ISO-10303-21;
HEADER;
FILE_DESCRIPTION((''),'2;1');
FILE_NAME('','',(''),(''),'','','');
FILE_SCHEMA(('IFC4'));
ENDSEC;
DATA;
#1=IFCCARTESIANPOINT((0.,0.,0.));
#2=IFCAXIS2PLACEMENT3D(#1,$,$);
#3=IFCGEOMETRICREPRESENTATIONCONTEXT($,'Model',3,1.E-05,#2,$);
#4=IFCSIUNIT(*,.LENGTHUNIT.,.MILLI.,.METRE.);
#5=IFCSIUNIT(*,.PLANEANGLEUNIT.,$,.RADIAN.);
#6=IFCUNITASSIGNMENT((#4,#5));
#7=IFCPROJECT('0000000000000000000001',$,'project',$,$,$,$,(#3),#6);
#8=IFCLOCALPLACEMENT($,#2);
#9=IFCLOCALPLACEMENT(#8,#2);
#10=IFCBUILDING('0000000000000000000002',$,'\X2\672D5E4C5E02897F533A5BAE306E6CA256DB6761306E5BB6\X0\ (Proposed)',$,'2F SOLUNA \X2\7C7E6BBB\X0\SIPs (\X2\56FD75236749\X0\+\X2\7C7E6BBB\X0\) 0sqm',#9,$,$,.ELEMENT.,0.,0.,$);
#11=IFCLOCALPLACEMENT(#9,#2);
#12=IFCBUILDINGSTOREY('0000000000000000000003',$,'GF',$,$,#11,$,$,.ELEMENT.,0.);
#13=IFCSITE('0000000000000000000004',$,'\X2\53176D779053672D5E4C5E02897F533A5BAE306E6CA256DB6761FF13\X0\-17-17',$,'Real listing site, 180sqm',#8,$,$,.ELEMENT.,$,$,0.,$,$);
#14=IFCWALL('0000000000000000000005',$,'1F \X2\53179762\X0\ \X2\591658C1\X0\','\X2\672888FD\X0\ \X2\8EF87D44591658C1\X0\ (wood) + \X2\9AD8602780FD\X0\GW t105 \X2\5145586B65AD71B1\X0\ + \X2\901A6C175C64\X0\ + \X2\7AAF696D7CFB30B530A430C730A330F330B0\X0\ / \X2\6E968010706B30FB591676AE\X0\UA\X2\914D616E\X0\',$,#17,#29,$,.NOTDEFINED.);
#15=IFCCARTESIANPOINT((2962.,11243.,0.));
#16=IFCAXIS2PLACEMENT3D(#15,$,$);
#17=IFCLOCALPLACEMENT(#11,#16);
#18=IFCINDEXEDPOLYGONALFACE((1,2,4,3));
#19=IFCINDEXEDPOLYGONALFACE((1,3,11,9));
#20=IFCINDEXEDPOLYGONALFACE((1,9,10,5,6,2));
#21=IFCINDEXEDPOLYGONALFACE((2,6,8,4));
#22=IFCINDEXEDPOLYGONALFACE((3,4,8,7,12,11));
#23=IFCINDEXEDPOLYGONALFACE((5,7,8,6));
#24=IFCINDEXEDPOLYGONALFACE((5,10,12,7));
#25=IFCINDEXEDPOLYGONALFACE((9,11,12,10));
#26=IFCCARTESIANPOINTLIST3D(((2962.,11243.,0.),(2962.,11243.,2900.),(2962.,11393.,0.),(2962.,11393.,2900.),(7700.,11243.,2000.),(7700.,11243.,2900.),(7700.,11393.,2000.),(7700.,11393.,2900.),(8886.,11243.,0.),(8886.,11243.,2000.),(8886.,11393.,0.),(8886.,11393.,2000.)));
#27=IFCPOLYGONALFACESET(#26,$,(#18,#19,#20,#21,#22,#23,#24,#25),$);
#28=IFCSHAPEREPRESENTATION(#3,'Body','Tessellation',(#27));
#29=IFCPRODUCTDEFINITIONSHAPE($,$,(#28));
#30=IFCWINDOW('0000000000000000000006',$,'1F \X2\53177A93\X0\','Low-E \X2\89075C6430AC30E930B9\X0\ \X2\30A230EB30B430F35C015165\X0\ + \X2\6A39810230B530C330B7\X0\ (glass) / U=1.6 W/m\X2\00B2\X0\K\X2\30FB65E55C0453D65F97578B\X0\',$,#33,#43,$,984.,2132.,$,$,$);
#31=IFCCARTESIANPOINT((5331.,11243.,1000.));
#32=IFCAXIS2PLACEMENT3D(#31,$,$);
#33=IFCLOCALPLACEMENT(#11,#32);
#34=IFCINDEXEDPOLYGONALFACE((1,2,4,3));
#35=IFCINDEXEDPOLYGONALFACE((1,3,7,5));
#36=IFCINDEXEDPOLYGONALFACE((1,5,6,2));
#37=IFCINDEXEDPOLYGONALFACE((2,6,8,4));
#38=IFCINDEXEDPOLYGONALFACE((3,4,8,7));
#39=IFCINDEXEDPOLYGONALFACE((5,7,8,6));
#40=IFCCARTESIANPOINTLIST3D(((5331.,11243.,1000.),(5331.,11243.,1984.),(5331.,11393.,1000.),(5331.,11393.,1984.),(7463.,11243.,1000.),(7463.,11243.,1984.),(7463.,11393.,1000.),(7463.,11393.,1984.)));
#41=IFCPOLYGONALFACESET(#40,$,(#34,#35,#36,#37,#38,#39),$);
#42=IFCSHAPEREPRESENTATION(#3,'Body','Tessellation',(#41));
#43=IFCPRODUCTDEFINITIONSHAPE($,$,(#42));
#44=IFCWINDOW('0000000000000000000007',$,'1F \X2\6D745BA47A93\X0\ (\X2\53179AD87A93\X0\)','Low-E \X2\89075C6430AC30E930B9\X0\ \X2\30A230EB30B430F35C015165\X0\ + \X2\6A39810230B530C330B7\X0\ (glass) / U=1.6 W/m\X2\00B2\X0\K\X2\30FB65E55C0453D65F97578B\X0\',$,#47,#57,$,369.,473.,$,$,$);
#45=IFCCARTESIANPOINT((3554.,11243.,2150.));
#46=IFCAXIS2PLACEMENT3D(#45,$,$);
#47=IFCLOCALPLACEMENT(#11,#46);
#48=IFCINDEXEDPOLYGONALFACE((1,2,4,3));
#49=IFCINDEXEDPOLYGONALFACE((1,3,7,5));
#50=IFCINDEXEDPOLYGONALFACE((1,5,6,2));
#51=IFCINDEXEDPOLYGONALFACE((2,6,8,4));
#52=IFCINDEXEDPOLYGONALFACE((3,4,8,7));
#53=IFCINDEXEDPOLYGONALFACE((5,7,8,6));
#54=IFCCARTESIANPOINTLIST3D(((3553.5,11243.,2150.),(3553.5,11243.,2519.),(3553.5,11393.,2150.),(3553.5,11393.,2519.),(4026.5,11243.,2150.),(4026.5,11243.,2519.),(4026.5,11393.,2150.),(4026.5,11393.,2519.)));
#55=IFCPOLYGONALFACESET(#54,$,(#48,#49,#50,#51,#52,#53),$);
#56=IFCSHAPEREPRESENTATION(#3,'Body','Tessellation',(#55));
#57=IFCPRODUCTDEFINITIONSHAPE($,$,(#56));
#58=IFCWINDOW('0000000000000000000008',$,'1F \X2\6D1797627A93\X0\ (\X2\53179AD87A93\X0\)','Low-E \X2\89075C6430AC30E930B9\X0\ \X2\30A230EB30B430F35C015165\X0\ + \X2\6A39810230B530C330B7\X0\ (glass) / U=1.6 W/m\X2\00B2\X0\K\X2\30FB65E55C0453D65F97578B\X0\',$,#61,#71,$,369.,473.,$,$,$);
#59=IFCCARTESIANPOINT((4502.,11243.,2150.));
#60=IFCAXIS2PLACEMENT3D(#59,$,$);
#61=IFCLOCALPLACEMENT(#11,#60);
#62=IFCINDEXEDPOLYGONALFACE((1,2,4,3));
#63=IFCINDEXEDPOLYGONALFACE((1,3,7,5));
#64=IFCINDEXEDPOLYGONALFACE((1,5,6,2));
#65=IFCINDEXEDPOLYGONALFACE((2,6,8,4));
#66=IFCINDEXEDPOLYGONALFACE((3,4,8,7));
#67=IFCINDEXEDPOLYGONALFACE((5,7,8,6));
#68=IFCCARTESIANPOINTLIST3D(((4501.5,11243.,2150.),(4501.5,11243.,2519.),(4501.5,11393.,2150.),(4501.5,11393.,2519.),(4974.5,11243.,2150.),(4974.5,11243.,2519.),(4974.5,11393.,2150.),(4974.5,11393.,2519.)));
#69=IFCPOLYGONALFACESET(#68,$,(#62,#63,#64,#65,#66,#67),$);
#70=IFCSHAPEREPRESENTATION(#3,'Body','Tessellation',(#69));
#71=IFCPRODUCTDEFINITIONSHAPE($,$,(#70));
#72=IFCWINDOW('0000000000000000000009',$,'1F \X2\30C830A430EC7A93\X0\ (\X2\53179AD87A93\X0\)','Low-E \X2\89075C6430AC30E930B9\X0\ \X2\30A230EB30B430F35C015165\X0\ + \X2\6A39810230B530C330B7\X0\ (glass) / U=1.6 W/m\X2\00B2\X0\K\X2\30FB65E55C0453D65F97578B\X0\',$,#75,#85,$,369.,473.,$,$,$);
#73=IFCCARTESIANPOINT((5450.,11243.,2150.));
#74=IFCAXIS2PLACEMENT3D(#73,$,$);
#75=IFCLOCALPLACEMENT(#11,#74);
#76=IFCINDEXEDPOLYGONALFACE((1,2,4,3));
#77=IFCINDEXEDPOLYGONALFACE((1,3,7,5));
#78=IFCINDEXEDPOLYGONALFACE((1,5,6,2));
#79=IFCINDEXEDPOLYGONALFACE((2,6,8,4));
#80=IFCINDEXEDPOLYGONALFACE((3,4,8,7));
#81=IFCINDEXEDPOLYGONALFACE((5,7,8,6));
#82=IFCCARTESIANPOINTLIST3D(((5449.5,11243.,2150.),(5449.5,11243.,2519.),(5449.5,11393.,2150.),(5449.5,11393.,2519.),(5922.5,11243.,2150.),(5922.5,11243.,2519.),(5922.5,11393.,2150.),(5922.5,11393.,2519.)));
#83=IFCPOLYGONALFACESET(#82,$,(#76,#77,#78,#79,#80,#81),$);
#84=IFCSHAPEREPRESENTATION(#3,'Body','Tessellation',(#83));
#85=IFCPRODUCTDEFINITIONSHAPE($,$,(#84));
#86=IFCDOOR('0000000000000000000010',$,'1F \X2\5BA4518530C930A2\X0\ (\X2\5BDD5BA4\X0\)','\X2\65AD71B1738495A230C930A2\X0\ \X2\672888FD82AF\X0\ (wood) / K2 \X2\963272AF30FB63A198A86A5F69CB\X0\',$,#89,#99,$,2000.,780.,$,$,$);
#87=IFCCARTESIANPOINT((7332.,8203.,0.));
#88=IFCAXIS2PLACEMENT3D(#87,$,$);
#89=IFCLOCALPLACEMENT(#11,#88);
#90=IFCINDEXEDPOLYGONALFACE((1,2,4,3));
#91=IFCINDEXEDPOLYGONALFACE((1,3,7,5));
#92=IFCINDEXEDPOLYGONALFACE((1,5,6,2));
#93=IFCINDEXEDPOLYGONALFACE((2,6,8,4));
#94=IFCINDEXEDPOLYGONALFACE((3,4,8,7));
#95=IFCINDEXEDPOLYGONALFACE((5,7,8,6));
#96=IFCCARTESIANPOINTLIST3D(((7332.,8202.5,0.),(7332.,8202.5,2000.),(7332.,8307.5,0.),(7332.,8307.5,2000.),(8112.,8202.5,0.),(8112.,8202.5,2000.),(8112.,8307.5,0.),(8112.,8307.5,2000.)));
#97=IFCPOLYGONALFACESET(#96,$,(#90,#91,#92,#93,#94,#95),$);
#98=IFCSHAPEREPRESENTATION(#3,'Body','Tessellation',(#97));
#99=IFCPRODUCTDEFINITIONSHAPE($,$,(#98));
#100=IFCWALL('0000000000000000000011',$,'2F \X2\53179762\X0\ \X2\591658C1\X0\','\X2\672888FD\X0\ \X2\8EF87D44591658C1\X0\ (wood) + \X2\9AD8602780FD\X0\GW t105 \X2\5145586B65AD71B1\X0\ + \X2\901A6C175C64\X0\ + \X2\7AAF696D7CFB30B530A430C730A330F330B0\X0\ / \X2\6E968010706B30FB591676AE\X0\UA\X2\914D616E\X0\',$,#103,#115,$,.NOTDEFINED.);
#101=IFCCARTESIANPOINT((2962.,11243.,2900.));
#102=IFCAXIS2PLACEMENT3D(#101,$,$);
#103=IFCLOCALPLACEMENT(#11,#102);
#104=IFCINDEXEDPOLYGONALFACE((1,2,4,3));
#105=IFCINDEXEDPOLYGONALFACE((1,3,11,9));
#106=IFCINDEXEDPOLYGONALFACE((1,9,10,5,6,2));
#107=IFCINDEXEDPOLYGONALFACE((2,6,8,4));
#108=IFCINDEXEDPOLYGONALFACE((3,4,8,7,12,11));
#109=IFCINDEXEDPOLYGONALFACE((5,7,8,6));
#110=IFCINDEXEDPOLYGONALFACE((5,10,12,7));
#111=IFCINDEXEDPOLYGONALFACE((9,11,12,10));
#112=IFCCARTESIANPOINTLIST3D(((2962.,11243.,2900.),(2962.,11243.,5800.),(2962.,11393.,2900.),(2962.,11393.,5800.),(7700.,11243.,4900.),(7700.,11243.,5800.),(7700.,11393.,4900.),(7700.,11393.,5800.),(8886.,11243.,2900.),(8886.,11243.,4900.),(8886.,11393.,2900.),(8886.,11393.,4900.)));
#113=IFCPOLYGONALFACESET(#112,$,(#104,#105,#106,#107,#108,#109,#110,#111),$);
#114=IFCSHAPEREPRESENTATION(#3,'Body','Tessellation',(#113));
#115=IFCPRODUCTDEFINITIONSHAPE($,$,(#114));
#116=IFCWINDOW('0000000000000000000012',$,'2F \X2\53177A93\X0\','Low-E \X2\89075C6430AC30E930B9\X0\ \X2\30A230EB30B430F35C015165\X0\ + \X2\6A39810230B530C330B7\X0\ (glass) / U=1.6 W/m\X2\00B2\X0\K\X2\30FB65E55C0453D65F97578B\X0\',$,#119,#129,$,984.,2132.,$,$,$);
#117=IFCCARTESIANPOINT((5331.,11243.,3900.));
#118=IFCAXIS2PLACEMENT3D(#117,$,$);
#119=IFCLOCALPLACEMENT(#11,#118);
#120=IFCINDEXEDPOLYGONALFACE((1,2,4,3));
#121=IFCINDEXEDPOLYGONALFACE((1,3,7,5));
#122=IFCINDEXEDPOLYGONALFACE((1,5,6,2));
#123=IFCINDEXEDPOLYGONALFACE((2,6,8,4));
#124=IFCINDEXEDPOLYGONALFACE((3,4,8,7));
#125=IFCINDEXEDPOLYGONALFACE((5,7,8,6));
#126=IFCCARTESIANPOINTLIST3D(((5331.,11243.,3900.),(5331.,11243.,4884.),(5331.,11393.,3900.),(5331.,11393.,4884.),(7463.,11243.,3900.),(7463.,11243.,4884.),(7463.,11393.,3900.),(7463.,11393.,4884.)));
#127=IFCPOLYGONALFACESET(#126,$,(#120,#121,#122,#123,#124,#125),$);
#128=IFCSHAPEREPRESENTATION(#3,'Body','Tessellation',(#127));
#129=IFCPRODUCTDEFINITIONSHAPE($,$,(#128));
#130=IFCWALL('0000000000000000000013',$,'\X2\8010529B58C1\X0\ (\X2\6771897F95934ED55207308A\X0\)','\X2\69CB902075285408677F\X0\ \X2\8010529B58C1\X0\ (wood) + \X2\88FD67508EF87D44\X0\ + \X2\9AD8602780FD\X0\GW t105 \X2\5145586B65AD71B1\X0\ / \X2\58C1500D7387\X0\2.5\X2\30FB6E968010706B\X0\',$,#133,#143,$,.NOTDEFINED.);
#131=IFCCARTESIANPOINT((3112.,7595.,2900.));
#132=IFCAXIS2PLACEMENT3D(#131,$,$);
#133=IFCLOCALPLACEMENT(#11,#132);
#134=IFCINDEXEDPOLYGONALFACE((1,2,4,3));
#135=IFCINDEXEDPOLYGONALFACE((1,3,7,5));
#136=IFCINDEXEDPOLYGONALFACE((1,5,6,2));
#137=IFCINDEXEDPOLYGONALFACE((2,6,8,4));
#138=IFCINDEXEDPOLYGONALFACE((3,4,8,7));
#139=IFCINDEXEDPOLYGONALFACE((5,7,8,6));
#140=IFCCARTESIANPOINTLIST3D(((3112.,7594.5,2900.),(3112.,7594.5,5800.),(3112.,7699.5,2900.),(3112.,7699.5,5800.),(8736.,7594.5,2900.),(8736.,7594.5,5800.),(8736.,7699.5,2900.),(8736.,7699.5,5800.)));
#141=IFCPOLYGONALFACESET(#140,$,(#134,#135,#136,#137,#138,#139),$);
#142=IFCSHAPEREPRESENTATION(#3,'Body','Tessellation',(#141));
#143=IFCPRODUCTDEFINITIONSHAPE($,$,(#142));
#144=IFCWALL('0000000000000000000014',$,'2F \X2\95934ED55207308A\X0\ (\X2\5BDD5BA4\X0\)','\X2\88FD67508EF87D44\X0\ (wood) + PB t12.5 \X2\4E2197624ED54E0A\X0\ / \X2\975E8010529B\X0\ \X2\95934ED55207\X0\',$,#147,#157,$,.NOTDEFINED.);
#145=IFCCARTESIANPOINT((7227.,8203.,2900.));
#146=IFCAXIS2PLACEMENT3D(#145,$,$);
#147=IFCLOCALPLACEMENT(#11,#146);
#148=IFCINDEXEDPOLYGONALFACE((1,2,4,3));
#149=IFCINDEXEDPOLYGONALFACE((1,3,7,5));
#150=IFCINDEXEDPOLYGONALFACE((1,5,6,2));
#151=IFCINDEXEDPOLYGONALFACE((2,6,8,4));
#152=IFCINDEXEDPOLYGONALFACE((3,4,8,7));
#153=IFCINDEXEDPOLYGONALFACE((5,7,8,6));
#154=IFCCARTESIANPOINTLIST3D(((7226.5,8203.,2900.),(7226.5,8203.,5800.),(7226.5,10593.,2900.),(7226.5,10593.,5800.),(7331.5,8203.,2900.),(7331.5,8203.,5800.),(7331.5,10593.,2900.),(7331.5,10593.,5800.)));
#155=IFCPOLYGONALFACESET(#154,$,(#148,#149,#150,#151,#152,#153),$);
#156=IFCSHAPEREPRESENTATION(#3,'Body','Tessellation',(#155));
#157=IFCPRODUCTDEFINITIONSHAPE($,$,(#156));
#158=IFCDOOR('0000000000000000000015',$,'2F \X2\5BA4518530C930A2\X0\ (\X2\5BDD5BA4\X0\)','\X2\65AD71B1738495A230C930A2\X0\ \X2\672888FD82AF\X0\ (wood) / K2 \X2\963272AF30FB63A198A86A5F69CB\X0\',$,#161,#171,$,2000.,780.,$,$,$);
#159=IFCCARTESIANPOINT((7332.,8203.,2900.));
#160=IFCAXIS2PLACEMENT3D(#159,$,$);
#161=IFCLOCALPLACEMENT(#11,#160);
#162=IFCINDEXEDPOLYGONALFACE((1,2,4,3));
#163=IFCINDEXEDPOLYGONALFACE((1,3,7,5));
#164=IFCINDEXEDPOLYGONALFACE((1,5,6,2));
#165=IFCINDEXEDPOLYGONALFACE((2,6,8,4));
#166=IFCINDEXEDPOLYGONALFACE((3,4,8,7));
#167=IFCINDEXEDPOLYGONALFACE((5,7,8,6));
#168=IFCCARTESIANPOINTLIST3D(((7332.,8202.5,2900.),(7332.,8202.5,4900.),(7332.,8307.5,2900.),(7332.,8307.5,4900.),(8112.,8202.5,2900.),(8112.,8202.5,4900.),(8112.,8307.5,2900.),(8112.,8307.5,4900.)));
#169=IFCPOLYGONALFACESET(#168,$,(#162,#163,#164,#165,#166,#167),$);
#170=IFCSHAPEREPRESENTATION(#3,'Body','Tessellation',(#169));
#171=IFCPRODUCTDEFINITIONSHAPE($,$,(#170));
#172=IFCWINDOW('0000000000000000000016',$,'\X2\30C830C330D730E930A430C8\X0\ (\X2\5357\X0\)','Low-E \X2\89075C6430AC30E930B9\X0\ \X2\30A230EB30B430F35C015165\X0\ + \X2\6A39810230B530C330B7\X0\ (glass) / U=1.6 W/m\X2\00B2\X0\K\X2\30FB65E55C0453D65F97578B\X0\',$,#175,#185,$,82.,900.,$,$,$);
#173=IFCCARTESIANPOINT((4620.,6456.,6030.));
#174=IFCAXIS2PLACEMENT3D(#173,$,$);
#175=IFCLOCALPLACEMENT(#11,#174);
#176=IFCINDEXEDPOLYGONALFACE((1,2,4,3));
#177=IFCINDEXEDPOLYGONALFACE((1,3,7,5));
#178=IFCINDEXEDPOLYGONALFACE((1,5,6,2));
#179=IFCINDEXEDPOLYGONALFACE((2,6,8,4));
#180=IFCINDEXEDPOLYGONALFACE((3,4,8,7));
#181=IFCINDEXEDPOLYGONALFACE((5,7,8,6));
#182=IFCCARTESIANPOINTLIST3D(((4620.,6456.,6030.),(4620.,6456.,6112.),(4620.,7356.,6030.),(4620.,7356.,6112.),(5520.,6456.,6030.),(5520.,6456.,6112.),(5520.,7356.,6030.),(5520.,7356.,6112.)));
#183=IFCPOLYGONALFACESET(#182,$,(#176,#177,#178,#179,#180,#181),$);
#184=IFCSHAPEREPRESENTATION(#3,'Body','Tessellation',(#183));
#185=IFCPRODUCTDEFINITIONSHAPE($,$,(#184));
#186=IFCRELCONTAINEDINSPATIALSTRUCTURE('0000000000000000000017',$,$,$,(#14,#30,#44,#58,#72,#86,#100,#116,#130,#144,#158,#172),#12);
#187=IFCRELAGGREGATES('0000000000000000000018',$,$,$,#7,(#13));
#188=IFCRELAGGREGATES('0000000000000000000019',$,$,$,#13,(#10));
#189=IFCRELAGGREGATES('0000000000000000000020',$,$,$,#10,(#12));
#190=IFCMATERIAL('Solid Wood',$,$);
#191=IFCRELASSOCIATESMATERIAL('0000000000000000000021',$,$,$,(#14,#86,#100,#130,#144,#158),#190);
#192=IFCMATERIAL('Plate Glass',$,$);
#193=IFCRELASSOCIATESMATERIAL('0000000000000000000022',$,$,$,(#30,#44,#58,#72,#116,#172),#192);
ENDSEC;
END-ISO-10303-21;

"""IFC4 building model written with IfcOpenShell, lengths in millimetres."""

from ifc_helpers import new_model, si_unit, frame, frame_2d, origin, place, context, project, spatial, rectangle, extrude, material, element, fill, save


model = new_model("IFC4")

# Units and contexts
model_context = context("Model", 3, precision=1e-05, world=origin())
ifc_project = project(units=[si_unit("LENGTHUNIT", "METRE", prefix="MILLI"), si_unit("PLANEANGLEUNIT", "RADIAN")], contexts=[model_context])

# Site, building, storey
site_placement = place(None, origin())
site = spatial("IfcSite", under=ifc_project, at=site_placement, Name="北海道札幌市西区宮の沢四条３-17-17", ObjectType="Real listing site, 180sqm", CompositionType="ELEMENT", RefElevation=0.0)
building_placement = place(site_placement, origin())
building = spatial("IfcBuilding", under=site, at=building_placement, Name="札幌市西区宮の沢四条の家 (Proposed)", ObjectType="2F SOLUNA 籾殻SIPs (国産杉+籾殻) 0sqm", CompositionType="ELEMENT", ElevationOfRefHeight=0.0, ElevationOfTerrain=0.0)
storey_placement = place(building_placement, origin())
storey = spatial("IfcBuildingStorey", under=building, at=storey_placement, Name="GF", CompositionType="ELEMENT", Elevation=0.0)

# Wall, openings, windows
ifc_material_1 = material(Name="Solid Wood")
wall_1_placement = place(storey_placement, frame((2962.0, 11243.0, 0.0)))
wall_1 = element("IfcWall", 1, at=wall_1_placement, inside=storey, material=ifc_material_1, Name="1F 北面 外壁", Description="木製 軸組外壁 (wood) + 高性能GW t105 充填断熱 + 通気層 + 窯業系サイディング / 準耐火・外皮UA配慮", PredefinedType="NOTDEFINED", context=model_context, shape_type="SweptSolid", body=[
    extrude(rectangle(XDim=5924.0, YDim=150.0, at=frame_2d((2962.0, 75.0))), frame((2962.0, 11243.0, 0.0)), (0.0, 0.0, 1.0), 2900.0),
])
opening_1_placement = place(storey_placement, frame((5331.0, 11243.0, 1000.0)))
opening_1 = element("IfcOpeningElement", 2, at=opening_1_placement, cuts=wall_1, PredefinedType="NOTDEFINED", context=model_context, shape_type="SweptSolid", body=[
    extrude(rectangle(XDim=2132.0, YDim=150.0, at=frame_2d((1066.0, 75.0))), frame((5331.0, 11243.0, 1000.0)), (0.0, 0.0, 1.0), 984.0),
])
opening_2_placement = place(storey_placement, frame((3554.0, 11243.0, 2150.0)))
opening_2 = element("IfcOpeningElement", 3, at=opening_2_placement, cuts=wall_1, PredefinedType="NOTDEFINED", context=model_context, shape_type="SweptSolid", body=[
    extrude(rectangle(XDim=473.0, YDim=150.0, at=frame_2d((236.0, 75.0))), frame((3554.0, 11243.0, 2150.0)), (0.0, 0.0, 1.0), 369.0),
])
opening_3_placement = place(storey_placement, frame((4502.0, 11243.0, 2150.0)))
opening_3 = element("IfcOpeningElement", 4, at=opening_3_placement, cuts=wall_1, PredefinedType="NOTDEFINED", context=model_context, shape_type="SweptSolid", body=[
    extrude(rectangle(XDim=473.0, YDim=150.0, at=frame_2d((236.0, 75.0))), frame((4502.0, 11243.0, 2150.0)), (0.0, 0.0, 1.0), 369.0),
])
opening_4_placement = place(storey_placement, frame((5450.0, 11243.0, 2150.0)))
opening_4 = element("IfcOpeningElement", 5, at=opening_4_placement, cuts=wall_1, PredefinedType="NOTDEFINED", context=model_context, shape_type="SweptSolid", body=[
    extrude(rectangle(XDim=473.0, YDim=150.0, at=frame_2d((236.0, 75.0))), frame((5450.0, 11243.0, 2150.0)), (0.0, 0.0, 1.0), 369.0),
])
ifc_material_2 = material(Name="Plate Glass")
window_1_placement = place(storey_placement, frame((5331.0, 11243.0, 1000.0)))
window_1 = element("IfcWindow", 6, at=window_1_placement, inside=storey, material=ifc_material_2, Name="1F 北窓", Description="Low-E 複層ガラス アルゴン封入 + 樹脂サッシ (glass) / U=1.6 W/m²K・日射取得型", OverallHeight=984.0, OverallWidth=2132.0, context=model_context, shape_type="SweptSolid", body=[
    extrude(rectangle(XDim=2132.0, YDim=150.0, at=frame_2d((1066.0, 75.0))), frame((5331.0, 11243.0, 1000.0)), (0.0, 0.0, 1.0), 984.0),
])
fill(opening_1, window_1)
window_2_placement = place(storey_placement, frame((3554.0, 11243.0, 2150.0)))
window_2 = element("IfcWindow", 7, at=window_2_placement, inside=storey, material=ifc_material_2, Name="1F 浴室窓 (北高窓)", Description="Low-E 複層ガラス アルゴン封入 + 樹脂サッシ (glass) / U=1.6 W/m²K・日射取得型", OverallHeight=369.0, OverallWidth=473.0, context=model_context, shape_type="SweptSolid", body=[
    extrude(rectangle(XDim=473.0, YDim=150.0, at=frame_2d((236.0, 75.0))), frame((3554.0, 11243.0, 2150.0)), (0.0, 0.0, 1.0), 369.0),
])
fill(opening_2, window_2)
window_3_placement = place(storey_placement, frame((4502.0, 11243.0, 2150.0)))
window_3 = element("IfcWindow", 8, at=window_3_placement, inside=storey, material=ifc_material_2, Name="1F 洗面窓 (北高窓)", Description="Low-E 複層ガラス アルゴン封入 + 樹脂サッシ (glass) / U=1.6 W/m²K・日射取得型", OverallHeight=369.0, OverallWidth=473.0, context=model_context, shape_type="SweptSolid", body=[
    extrude(rectangle(XDim=473.0, YDim=150.0, at=frame_2d((236.0, 75.0))), frame((4502.0, 11243.0, 2150.0)), (0.0, 0.0, 1.0), 369.0),
])
fill(opening_3, window_3)
window_4_placement = place(storey_placement, frame((5450.0, 11243.0, 2150.0)))
window_4 = element("IfcWindow", 9, at=window_4_placement, inside=storey, material=ifc_material_2, Name="1F トイレ窓 (北高窓)", Description="Low-E 複層ガラス アルゴン封入 + 樹脂サッシ (glass) / U=1.6 W/m²K・日射取得型", OverallHeight=369.0, OverallWidth=473.0, context=model_context, shape_type="SweptSolid", body=[
    extrude(rectangle(XDim=473.0, YDim=150.0, at=frame_2d((236.0, 75.0))), frame((5450.0, 11243.0, 2150.0)), (0.0, 0.0, 1.0), 369.0),
])
fill(opening_4, window_4)

# Door
door_1_placement = place(storey_placement, frame((7332.0, 8203.0, 0.0)))
element("IfcDoor", 10, at=door_1_placement, inside=storey, material=ifc_material_1, Name="1F 室内ドア (寝室)", Description="断熱玄関ドア 木製芯 (wood) / K2 防犯・採風機構", OverallHeight=2000.0, OverallWidth=780.0, context=model_context, shape_type="SweptSolid", body=[
    extrude(rectangle(XDim=780.0, YDim=105.0, at=frame_2d((390.0, 52.0))), frame((7332.0, 8203.0, 0.0)), (0.0, 0.0, 1.0), 2000.0),
])

# Wall, opening, window
wall_2_placement = place(storey_placement, frame((2962.0, 11243.0, 2900.0)))
wall_2 = element("IfcWall", 11, at=wall_2_placement, inside=storey, material=ifc_material_1, Name="2F 北面 外壁", Description="木製 軸組外壁 (wood) + 高性能GW t105 充填断熱 + 通気層 + 窯業系サイディング / 準耐火・外皮UA配慮", PredefinedType="NOTDEFINED", context=model_context, shape_type="SweptSolid", body=[
    extrude(rectangle(XDim=5924.0, YDim=150.0, at=frame_2d((2962.0, 75.0))), frame((2962.0, 11243.0, 2900.0)), (0.0, 0.0, 1.0), 2900.0),
])
opening_5_placement = place(storey_placement, frame((5331.0, 11243.0, 3900.0)))
opening_5 = element("IfcOpeningElement", 12, at=opening_5_placement, cuts=wall_2, PredefinedType="NOTDEFINED", context=model_context, shape_type="SweptSolid", body=[
    extrude(rectangle(XDim=2132.0, YDim=150.0, at=frame_2d((1066.0, 75.0))), frame((5331.0, 11243.0, 3900.0)), (0.0, 0.0, 1.0), 984.0),
])
window_5_placement = place(storey_placement, frame((5331.0, 11243.0, 3900.0)))
window_5 = element("IfcWindow", 13, at=window_5_placement, inside=storey, material=ifc_material_2, Name="2F 北窓", Description="Low-E 複層ガラス アルゴン封入 + 樹脂サッシ (glass) / U=1.6 W/m²K・日射取得型", OverallHeight=984.0, OverallWidth=2132.0, context=model_context, shape_type="SweptSolid", body=[
    extrude(rectangle(XDim=2132.0, YDim=150.0, at=frame_2d((1066.0, 75.0))), frame((5331.0, 11243.0, 3900.0)), (0.0, 0.0, 1.0), 984.0),
])
fill(opening_5, window_5)

# Walls
wall_3_placement = place(storey_placement, frame((3112.0, 7595.0, 2900.0)))
element("IfcWall", 14, at=wall_3_placement, inside=storey, material=ifc_material_1, Name="耐力壁 (東西間仕切り)", Description="構造用合板 耐力壁 (wood) + 製材軸組 + 高性能GW t105 充填断熱 / 壁倍率2.5・準耐火", PredefinedType="NOTDEFINED", context=model_context, shape_type="SweptSolid", body=[
    extrude(rectangle(XDim=5624.0, YDim=105.0, at=frame_2d((2812.0, 52.0))), frame((3112.0, 7595.0, 2900.0)), (0.0, 0.0, 1.0), 2900.0),
])
wall_4_placement = place(storey_placement, frame((7227.0, 8203.0, 2900.0)))
element("IfcWall", 15, at=wall_4_placement, inside=storey, material=ifc_material_1, Name="2F 間仕切り (寝室)", Description="製材軸組 (wood) + PB t12.5 両面仕上 / 非耐力 間仕切", PredefinedType="NOTDEFINED", context=model_context, shape_type="SweptSolid", body=[
    extrude(rectangle(XDim=105.0, YDim=2390.0, at=frame_2d((52.0, 1195.0))), frame((7227.0, 8203.0, 2900.0)), (0.0, 0.0, 1.0), 2900.0),
])

# Door
door_2_placement = place(storey_placement, frame((7332.0, 8203.0, 2900.0)))
element("IfcDoor", 16, at=door_2_placement, inside=storey, material=ifc_material_1, Name="2F 室内ドア (寝室)", Description="断熱玄関ドア 木製芯 (wood) / K2 防犯・採風機構", OverallHeight=2000.0, OverallWidth=780.0, context=model_context, shape_type="SweptSolid", body=[
    extrude(rectangle(XDim=780.0, YDim=105.0, at=frame_2d((390.0, 52.0))), frame((7332.0, 8203.0, 2900.0)), (0.0, 0.0, 1.0), 2000.0),
])

# Window
window_6_placement = place(storey_placement, frame((4620.0, 6456.0, 6030.0)))
element("IfcWindow", 17, at=window_6_placement, inside=storey, material=ifc_material_2, Name="トップライト (南)", Description="Low-E 複層ガラス アルゴン封入 + 樹脂サッシ (glass) / U=1.6 W/m²K・日射取得型", OverallHeight=82.0, OverallWidth=900.0, context=model_context, shape_type="SweptSolid", body=[
    extrude(rectangle(XDim=900.0, YDim=900.0, at=frame_2d((450.0, 450.0))), frame((4620.0, 6456.0, 6030.0)), (0.0, 0.0, 1.0), 82.0),
])

save(model, "model.ifc")
